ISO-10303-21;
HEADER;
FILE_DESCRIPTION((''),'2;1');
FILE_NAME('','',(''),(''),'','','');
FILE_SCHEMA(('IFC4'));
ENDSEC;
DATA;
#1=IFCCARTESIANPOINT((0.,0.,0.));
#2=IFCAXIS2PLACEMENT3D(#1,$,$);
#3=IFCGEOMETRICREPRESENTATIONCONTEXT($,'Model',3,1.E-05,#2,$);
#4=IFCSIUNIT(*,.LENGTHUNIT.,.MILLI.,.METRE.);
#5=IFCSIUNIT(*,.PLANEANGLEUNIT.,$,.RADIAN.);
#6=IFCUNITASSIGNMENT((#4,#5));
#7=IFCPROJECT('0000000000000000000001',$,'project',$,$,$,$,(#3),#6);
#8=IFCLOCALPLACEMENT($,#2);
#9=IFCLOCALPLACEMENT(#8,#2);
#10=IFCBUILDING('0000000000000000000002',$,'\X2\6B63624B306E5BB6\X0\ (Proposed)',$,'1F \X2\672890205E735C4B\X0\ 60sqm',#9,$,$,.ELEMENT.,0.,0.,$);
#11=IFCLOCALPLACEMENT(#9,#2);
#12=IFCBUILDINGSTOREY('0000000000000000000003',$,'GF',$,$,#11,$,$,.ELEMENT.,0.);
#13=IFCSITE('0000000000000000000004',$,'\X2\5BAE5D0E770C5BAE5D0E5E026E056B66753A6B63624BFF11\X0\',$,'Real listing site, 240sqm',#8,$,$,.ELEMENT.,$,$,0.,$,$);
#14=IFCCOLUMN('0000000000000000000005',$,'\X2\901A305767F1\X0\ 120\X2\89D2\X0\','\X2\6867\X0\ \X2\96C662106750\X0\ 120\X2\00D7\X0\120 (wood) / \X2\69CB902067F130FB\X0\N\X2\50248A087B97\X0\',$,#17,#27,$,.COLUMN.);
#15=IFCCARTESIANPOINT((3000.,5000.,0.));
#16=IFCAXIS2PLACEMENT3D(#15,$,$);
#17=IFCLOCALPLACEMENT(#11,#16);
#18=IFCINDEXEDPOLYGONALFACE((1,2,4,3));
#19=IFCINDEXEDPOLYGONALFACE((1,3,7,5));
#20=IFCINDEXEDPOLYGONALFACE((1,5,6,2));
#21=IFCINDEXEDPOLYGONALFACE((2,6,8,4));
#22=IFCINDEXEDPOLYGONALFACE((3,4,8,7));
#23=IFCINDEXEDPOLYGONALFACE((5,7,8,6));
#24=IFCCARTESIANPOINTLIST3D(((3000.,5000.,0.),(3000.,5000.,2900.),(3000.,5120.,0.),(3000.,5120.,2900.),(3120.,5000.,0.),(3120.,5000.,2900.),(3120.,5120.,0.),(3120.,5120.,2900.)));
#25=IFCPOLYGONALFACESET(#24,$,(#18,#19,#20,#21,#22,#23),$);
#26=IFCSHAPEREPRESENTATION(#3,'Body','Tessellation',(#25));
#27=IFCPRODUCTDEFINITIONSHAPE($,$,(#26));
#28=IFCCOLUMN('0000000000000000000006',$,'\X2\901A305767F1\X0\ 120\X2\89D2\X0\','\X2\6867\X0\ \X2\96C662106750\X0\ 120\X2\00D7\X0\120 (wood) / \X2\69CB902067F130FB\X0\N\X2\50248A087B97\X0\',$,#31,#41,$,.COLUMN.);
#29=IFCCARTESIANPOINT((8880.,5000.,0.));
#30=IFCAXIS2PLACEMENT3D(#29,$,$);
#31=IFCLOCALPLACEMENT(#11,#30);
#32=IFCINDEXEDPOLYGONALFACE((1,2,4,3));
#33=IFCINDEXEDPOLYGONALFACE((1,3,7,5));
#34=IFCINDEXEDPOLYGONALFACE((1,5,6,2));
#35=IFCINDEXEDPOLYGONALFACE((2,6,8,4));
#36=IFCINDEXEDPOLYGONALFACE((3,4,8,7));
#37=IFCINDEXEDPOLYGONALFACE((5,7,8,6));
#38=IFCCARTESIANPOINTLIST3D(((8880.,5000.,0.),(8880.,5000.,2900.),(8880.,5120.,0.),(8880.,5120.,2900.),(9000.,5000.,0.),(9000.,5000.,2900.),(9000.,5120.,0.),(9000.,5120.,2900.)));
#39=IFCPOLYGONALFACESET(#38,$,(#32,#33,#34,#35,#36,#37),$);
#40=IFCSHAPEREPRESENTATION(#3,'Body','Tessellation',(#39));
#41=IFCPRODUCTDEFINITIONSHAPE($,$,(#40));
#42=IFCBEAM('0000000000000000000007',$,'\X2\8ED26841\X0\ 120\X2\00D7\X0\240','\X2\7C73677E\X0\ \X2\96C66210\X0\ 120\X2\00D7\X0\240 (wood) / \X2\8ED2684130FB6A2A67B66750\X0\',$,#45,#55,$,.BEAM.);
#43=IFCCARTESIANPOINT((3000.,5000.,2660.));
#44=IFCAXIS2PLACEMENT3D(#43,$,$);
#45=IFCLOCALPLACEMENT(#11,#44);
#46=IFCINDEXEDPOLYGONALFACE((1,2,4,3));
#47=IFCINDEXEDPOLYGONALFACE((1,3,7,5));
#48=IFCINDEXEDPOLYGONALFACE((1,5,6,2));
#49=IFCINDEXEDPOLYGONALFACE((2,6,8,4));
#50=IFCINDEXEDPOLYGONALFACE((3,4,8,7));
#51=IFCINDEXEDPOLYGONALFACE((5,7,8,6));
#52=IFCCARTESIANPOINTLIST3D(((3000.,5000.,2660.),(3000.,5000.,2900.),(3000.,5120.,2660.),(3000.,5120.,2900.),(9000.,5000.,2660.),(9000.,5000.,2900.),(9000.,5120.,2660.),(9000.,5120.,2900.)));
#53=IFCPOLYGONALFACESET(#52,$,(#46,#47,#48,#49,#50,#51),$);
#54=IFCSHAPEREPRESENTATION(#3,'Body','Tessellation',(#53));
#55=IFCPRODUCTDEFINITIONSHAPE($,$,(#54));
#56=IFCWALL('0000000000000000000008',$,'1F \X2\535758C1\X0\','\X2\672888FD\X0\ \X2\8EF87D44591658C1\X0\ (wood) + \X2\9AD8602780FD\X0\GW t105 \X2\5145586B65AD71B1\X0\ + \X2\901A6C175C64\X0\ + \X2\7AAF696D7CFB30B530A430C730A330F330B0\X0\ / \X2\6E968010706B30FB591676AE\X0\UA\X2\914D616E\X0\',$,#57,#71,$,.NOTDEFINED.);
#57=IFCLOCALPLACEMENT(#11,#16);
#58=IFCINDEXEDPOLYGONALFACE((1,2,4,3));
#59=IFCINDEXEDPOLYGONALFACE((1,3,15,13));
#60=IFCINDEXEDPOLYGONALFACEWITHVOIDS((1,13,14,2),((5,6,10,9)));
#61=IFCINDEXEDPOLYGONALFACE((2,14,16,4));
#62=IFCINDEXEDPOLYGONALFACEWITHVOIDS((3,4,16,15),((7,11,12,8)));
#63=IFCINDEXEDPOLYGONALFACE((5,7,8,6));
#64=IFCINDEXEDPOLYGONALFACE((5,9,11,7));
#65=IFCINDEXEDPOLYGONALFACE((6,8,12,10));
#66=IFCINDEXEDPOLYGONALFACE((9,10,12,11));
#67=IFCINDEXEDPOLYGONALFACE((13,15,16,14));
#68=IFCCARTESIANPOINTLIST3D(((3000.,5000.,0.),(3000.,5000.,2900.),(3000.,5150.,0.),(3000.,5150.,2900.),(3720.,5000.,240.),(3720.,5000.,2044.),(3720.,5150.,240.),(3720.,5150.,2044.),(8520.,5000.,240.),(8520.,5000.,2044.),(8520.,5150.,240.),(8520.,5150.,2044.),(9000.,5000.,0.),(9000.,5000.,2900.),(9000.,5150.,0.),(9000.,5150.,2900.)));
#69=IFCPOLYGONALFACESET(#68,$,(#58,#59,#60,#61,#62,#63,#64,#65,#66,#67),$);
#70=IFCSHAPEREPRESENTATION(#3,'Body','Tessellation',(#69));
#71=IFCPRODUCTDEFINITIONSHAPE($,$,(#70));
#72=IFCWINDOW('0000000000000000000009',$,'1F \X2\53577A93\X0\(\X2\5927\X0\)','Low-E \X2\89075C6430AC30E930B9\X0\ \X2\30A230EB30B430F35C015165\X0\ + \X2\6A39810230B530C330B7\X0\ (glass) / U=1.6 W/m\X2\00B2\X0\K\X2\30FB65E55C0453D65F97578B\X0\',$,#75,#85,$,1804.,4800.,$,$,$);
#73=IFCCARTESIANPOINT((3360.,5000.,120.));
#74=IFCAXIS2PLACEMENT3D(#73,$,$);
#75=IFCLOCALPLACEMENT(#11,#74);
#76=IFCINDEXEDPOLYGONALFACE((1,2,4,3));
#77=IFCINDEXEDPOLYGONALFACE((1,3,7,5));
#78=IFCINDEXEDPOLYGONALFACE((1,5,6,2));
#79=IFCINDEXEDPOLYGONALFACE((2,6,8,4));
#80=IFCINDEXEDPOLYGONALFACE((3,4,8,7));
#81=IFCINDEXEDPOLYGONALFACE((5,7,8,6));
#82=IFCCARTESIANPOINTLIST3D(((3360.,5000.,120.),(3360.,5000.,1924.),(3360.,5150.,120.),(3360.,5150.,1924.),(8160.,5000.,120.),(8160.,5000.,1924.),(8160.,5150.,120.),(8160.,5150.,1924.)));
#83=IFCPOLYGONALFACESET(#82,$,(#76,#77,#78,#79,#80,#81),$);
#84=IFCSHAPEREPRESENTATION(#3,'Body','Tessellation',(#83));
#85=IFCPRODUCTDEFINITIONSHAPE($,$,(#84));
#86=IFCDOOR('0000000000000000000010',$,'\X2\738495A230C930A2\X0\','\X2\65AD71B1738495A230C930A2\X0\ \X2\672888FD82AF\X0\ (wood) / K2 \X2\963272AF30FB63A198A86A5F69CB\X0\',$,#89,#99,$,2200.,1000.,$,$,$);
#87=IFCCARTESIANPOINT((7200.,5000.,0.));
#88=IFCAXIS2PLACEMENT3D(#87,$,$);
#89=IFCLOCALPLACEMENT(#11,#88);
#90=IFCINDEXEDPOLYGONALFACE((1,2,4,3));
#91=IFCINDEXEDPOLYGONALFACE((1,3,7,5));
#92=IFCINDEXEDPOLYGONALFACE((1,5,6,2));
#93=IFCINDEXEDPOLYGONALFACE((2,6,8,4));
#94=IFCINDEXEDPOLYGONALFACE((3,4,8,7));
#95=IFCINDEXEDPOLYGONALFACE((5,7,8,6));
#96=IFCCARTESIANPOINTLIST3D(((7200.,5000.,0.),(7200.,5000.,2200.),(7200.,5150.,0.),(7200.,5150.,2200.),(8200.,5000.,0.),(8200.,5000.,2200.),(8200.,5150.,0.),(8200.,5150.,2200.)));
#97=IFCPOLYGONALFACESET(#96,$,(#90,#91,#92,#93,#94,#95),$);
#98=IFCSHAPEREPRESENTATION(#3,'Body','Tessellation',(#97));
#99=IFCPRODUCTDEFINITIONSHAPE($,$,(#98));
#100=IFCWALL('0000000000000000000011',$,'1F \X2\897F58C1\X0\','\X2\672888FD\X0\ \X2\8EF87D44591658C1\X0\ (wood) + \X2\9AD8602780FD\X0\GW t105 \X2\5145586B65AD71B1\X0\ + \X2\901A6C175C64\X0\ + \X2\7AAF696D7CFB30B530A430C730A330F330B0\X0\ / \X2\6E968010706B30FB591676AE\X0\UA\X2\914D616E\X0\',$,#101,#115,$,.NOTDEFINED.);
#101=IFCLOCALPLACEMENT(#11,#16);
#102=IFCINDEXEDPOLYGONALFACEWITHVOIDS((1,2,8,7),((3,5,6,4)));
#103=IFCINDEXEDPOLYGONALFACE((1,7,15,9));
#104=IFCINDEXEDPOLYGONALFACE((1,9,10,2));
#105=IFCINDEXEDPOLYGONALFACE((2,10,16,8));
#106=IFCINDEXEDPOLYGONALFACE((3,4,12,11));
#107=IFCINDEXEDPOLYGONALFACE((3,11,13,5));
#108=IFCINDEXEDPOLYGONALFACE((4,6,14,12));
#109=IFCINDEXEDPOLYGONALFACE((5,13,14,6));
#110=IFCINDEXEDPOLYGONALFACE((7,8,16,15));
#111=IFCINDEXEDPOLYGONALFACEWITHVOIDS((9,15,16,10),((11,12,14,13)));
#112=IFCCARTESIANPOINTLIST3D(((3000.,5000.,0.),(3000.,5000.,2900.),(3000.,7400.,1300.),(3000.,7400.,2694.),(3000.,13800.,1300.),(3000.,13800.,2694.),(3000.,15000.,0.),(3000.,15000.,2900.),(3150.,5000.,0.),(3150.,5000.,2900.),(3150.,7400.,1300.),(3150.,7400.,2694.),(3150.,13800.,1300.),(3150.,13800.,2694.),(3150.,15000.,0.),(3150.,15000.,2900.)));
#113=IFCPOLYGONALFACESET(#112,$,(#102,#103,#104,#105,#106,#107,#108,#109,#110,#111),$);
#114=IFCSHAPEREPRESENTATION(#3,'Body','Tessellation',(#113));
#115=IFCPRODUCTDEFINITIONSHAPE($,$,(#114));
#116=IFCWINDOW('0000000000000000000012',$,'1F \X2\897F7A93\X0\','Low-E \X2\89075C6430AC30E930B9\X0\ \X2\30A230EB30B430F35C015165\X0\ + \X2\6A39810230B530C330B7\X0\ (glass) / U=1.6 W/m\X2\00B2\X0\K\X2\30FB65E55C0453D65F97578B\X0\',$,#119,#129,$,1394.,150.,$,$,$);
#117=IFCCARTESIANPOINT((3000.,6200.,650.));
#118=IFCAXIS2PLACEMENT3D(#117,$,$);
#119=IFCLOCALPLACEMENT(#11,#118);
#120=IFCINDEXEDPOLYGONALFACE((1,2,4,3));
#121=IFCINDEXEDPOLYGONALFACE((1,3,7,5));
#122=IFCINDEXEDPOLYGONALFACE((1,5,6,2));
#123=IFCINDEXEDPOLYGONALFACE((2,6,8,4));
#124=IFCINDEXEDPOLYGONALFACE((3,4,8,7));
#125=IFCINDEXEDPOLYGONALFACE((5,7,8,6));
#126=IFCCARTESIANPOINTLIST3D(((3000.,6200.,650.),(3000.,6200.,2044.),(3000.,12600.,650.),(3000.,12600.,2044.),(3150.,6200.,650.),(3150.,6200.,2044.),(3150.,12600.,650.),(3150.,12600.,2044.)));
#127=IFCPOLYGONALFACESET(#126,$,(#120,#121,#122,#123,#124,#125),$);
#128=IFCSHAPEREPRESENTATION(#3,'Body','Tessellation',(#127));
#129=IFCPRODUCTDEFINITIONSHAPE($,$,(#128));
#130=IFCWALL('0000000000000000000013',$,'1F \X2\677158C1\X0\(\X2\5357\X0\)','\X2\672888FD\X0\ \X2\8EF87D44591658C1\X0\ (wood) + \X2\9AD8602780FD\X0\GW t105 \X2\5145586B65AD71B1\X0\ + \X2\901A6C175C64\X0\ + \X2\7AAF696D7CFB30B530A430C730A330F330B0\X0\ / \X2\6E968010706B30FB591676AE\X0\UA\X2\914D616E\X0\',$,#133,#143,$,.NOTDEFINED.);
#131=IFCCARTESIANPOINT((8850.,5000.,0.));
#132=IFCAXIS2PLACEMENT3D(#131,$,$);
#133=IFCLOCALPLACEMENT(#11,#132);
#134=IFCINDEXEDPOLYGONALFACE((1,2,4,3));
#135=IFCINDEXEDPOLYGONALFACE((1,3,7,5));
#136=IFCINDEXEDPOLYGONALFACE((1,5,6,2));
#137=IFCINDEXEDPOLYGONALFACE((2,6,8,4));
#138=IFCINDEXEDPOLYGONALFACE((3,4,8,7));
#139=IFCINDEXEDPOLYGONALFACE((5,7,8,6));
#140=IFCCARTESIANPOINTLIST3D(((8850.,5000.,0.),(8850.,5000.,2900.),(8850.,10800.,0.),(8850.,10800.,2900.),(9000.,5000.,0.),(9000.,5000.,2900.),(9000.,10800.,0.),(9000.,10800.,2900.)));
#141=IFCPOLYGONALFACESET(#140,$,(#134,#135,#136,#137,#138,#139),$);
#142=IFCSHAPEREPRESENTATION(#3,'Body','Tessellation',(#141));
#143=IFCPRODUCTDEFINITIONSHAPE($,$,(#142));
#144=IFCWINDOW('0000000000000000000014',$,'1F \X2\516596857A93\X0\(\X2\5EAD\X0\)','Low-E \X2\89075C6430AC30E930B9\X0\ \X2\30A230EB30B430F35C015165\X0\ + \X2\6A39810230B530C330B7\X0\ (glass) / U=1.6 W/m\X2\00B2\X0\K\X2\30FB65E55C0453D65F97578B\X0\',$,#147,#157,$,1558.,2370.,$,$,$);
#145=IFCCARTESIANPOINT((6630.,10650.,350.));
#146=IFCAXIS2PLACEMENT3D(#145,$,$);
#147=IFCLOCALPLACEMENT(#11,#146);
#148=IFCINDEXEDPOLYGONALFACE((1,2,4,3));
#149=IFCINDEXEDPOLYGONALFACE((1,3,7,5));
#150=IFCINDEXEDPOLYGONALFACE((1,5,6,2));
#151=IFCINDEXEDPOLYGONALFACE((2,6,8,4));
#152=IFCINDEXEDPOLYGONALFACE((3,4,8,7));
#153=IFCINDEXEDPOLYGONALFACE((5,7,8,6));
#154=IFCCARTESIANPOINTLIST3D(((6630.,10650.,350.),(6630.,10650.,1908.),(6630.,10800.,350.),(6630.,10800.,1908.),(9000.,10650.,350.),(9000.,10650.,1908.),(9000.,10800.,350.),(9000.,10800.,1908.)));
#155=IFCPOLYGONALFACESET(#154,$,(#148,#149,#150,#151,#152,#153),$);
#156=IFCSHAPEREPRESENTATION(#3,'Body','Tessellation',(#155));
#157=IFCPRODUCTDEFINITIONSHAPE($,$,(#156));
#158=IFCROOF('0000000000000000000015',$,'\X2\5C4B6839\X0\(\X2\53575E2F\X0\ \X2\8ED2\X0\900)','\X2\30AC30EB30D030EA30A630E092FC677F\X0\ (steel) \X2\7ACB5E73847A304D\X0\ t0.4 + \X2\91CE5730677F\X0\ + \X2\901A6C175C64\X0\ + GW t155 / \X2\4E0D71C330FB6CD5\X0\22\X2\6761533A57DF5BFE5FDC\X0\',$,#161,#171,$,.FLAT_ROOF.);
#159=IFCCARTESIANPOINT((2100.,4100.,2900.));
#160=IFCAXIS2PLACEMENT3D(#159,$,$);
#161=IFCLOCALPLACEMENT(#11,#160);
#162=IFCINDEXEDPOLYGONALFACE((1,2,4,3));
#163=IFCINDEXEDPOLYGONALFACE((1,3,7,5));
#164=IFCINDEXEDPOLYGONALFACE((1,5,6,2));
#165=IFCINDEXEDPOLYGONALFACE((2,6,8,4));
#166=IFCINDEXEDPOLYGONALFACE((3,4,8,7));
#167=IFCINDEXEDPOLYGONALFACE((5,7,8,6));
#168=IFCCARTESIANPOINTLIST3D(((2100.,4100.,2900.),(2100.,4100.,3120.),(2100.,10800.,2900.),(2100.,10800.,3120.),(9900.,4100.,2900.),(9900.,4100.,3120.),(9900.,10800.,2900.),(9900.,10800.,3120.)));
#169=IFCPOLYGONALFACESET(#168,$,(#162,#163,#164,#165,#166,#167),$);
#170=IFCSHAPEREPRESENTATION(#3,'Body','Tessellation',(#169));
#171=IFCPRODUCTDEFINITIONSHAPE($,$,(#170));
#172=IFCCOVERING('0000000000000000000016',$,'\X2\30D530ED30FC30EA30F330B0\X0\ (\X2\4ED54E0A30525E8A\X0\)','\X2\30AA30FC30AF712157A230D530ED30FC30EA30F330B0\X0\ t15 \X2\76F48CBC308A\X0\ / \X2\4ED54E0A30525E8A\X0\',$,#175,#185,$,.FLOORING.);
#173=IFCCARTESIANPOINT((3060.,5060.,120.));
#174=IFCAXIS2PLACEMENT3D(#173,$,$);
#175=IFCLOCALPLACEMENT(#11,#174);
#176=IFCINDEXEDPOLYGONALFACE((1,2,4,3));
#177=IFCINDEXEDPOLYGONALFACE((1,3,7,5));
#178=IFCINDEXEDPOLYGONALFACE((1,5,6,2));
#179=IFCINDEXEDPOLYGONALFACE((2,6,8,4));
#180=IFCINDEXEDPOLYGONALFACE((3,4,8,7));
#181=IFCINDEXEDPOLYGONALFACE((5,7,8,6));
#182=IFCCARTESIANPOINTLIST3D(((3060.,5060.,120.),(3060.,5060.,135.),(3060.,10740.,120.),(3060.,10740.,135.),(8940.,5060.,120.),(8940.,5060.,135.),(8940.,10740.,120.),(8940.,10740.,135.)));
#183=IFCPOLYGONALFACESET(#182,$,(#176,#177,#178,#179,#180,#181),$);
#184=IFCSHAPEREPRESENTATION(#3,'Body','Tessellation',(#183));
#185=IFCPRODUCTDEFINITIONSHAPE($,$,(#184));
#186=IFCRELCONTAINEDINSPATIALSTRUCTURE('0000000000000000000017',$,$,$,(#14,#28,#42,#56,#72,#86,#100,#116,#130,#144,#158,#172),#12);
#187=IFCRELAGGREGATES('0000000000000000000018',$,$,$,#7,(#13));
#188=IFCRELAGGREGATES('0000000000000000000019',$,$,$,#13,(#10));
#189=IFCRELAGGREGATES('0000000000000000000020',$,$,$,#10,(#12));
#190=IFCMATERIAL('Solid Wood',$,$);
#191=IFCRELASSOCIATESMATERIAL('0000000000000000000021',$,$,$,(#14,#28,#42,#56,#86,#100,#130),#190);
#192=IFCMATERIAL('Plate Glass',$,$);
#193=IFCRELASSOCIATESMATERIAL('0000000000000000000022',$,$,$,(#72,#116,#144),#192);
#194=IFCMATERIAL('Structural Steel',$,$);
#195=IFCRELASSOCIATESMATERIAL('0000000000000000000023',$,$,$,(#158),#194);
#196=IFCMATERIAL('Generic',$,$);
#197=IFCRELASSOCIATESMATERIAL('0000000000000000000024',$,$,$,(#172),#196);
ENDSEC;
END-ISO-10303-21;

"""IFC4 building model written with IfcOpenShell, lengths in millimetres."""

from ifc_helpers import new_model, si_unit, frame, frame_2d, origin, place, context, project, spatial, rectangle, extrude, material, element, fill, save


model = new_model("IFC4")

# Units and contexts
model_context = context("Model", 3, precision=1e-05, world=origin())
ifc_project = project(units=[si_unit("LENGTHUNIT", "METRE", prefix="MILLI"), si_unit("PLANEANGLEUNIT", "RADIAN")], contexts=[model_context])

# Site, building, storey
site_placement = place(None, origin())
site = spatial("IfcSite", under=ifc_project, at=site_placement, Name="宮崎県宮崎市清武町正手１", ObjectType="Real listing site, 240sqm", CompositionType="ELEMENT", RefElevation=0.0)
building_placement = place(site_placement, origin())
building = spatial("IfcBuilding", under=site, at=building_placement, Name="正手の家 (Proposed)", ObjectType="1F 木造平屋 60sqm", CompositionType="ELEMENT", ElevationOfRefHeight=0.0, ElevationOfTerrain=0.0)
storey_placement = place(building_placement, origin())
storey = spatial("IfcBuildingStorey", under=building, at=storey_placement, Name="GF", CompositionType="ELEMENT", Elevation=0.0)

# Columns
ifc_material_1 = material(Name="Solid Wood")
column_1_placement = place(storey_placement, frame((3000.0, 5000.0, 0.0)))
element("IfcColumn", 1, at=column_1_placement, inside=storey, material=ifc_material_1, Name="通し柱 120角", Description="桧 集成材 120×120 (wood) / 構造柱・N値計算", PredefinedType="COLUMN", context=model_context, shape_type="SweptSolid", body=[
    extrude(rectangle(XDim=120.0, YDim=120.0, at=frame_2d((60.0, 60.0))), frame((3000.0, 5000.0, 0.0)), (0.0, 0.0, 1.0), 2900.0),
])
column_2_placement = place(storey_placement, frame((8880.0, 5000.0, 0.0)))
element("IfcColumn", 2, at=column_2_placement, inside=storey, material=ifc_material_1, Name="通し柱 120角", Description="桧 集成材 120×120 (wood) / 構造柱・N値計算", PredefinedType="COLUMN", context=model_context, shape_type="SweptSolid", body=[
    extrude(rectangle(XDim=120.0, YDim=120.0, at=frame_2d((60.0, 60.0))), frame((8880.0, 5000.0, 0.0)), (0.0, 0.0, 1.0), 2900.0),
])

# Beam
beam_1_placement = place(storey_placement, frame((3000.0, 5000.0, 2660.0)))
element("IfcBeam", 3, at=beam_1_placement, inside=storey, material=ifc_material_1, Name="軒桁 120×240", Description="米松 集成 120×240 (wood) / 軒桁・横架材", PredefinedType="BEAM", context=model_context, shape_type="SweptSolid", body=[
    extrude(rectangle(XDim=6000.0, YDim=120.0, at=frame_2d((3000.0, 60.0))), frame((3000.0, 5000.0, 2660.0)), (0.0, 0.0, 1.0), 240.0),
])

# Wall, openings, window, door
wall_1_placement = place(storey_placement, frame((3000.0, 5000.0, 0.0)))
wall_1 = element("IfcWall", 4, at=wall_1_placement, inside=storey, material=ifc_material_1, Name="1F 南壁", Description="木製 軸組外壁 (wood) + 高性能GW t105 充填断熱 + 通気層 + 窯業系サイディング / 準耐火・外皮UA配慮", PredefinedType="NOTDEFINED", context=model_context, shape_type="SweptSolid", body=[
    extrude(rectangle(XDim=6000.0, YDim=150.0, at=frame_2d((3000.0, 75.0))), frame((3000.0, 5000.0, 0.0)), (0.0, 0.0, 1.0), 2900.0),
])
opening_1_placement = place(storey_placement, frame((3360.0, 5000.0, 120.0)))
opening_1 = element("IfcOpeningElement", 5, at=opening_1_placement, cuts=wall_1, PredefinedType="NOTDEFINED", context=model_context, shape_type="SweptSolid", body=[
    extrude(rectangle(XDim=4800.0, YDim=150.0, at=frame_2d((2400.0, 75.0))), frame((3360.0, 5000.0, 120.0)), (0.0, 0.0, 1.0), 1804.0),
])
opening_2_placement = place(storey_placement, frame((7200.0, 5000.0, 0.0)))
opening_2 = element("IfcOpeningElement", 6, at=opening_2_placement, cuts=wall_1, PredefinedType="NOTDEFINED", context=model_context, shape_type="SweptSolid", body=[
    extrude(rectangle(XDim=1000.0, YDim=150.0, at=frame_2d((500.0, 75.0))), frame((7200.0, 5000.0, 0.0)), (0.0, 0.0, 1.0), 2200.0),
])
ifc_material_2 = material(Name="Plate Glass")
window_1_placement = place(storey_placement, frame((3360.0, 5000.0, 120.0)))
window_1 = element("IfcWindow", 7, at=window_1_placement, inside=storey, material=ifc_material_2, Name="1F 南窓(大)", Description="Low-E 複層ガラス アルゴン封入 + 樹脂サッシ (glass) / U=1.6 W/m²K・日射取得型", OverallHeight=1804.0, OverallWidth=4800.0, context=model_context, shape_type="SweptSolid", body=[
    extrude(rectangle(XDim=4800.0, YDim=150.0, at=frame_2d((2400.0, 75.0))), frame((3360.0, 5000.0, 120.0)), (0.0, 0.0, 1.0), 1804.0),
])
fill(opening_1, window_1)
door_1_placement = place(storey_placement, frame((7200.0, 5000.0, 0.0)))
door_1 = element("IfcDoor", 8, at=door_1_placement, inside=storey, material=ifc_material_1, Name="玄関ドア", Description="断熱玄関ドア 木製芯 (wood) / K2 防犯・採風機構", OverallHeight=2200.0, OverallWidth=1000.0, context=model_context, shape_type="SweptSolid", body=[
    extrude(rectangle(XDim=1000.0, YDim=150.0, at=frame_2d((500.0, 75.0))), frame((7200.0, 5000.0, 0.0)), (0.0, 0.0, 1.0), 2200.0),
])
fill(opening_2, door_1)

# Walls, openings, windows
wall_2_placement = place(storey_placement, frame((3000.0, 5000.0, 0.0)))
wall_2 = element("IfcWall", 9, at=wall_2_placement, inside=storey, material=ifc_material_1, Name="1F 西壁", Description="木製 軸組外壁 (wood) + 高性能GW t105 充填断熱 + 通気層 + 窯業系サイディング / 準耐火・外皮UA配慮", PredefinedType="NOTDEFINED", context=model_context, shape_type="SweptSolid", body=[
    extrude(rectangle(XDim=150.0, YDim=10000.0, at=frame_2d((75.0, 5000.0))), frame((3000.0, 5000.0, 0.0)), (0.0, 0.0, 1.0), 2900.0),
])
opening_3_placement = place(storey_placement, frame((3000.0, 6200.0, 650.0)))
opening_3 = element("IfcOpeningElement", 10, at=opening_3_placement, cuts=wall_2, PredefinedType="NOTDEFINED", context=model_context, shape_type="SweptSolid", body=[
    extrude(rectangle(XDim=150.0, YDim=6400.0, at=frame_2d((75.0, 3200.0))), frame((3000.0, 6200.0, 650.0)), (0.0, 0.0, 1.0), 1394.0),
])
window_2_placement = place(storey_placement, frame((3000.0, 6200.0, 650.0)))
window_2 = element("IfcWindow", 11, at=window_2_placement, inside=storey, material=ifc_material_2, Name="1F 西窓", Description="Low-E 複層ガラス アルゴン封入 + 樹脂サッシ (glass) / U=1.6 W/m²K・日射取得型", OverallHeight=1394.0, OverallWidth=150.0, context=model_context, shape_type="SweptSolid", body=[
    extrude(rectangle(XDim=150.0, YDim=6400.0, at=frame_2d((75.0, 3200.0))), frame((3000.0, 6200.0, 650.0)), (0.0, 0.0, 1.0), 1394.0),
])
fill(opening_3, window_2)
wall_3_placement = place(storey_placement, frame((8850.0, 5000.0, 0.0)))
wall_3 = element("IfcWall", 12, at=wall_3_placement, inside=storey, material=ifc_material_1, Name="1F 東壁(南)", Description="木製 軸組外壁 (wood) + 高性能GW t105 充填断熱 + 通気層 + 窯業系サイディング / 準耐火・外皮UA配慮", PredefinedType="NOTDEFINED", context=model_context, shape_type="SweptSolid", body=[
    extrude(rectangle(XDim=150.0, YDim=5800.0, at=frame_2d((75.0, 2900.0))), frame((8850.0, 5000.0, 0.0)), (0.0, 0.0, 1.0), 2900.0),
])
opening_4_placement = place(storey_placement, frame((6630.0, 10650.0, 350.0)))
opening_4 = element("IfcOpeningElement", 13, at=opening_4_placement, cuts=wall_3, PredefinedType="NOTDEFINED", context=model_context, shape_type="SweptSolid", body=[
    extrude(rectangle(XDim=2370.0, YDim=150.0, at=frame_2d((1185.0, 75.0))), frame((6630.0, 10650.0, 350.0)), (0.0, 0.0, 1.0), 1558.0),
])
window_3_placement = place(storey_placement, frame((6630.0, 10650.0, 350.0)))
window_3 = element("IfcWindow", 14, at=window_3_placement, inside=storey, material=ifc_material_2, Name="1F 入隅窓(庭)", Description="Low-E 複層ガラス アルゴン封入 + 樹脂サッシ (glass) / U=1.6 W/m²K・日射取得型", OverallHeight=1558.0, OverallWidth=2370.0, context=model_context, shape_type="SweptSolid", body=[
    extrude(rectangle(XDim=2370.0, YDim=150.0, at=frame_2d((1185.0, 75.0))), frame((6630.0, 10650.0, 350.0)), (0.0, 0.0, 1.0), 1558.0),
])
fill(opening_4, window_3)

# Roof
ifc_material_3 = material(Name="Structural Steel")
roof_placement = place(storey_placement, frame((2100.0, 4100.0, 2900.0)))
element("IfcRoof", 15, at=roof_placement, inside=storey, material=ifc_material_3, Name="屋根(南帯 軒900)", Description="ガルバリウム鋼板 (steel) 立平葺き t0.4 + 野地板 + 通気層 + GW t155 / 不燃・法22条区域対応", PredefinedType="FLAT_ROOF", context=model_context, shape_type="SweptSolid", body=[
    extrude(rectangle(XDim=7800.0, YDim=6700.0, at=frame_2d((3900.0, 3350.0))), frame((2100.0, 4100.0, 2900.0)), (0.0, 0.0, 1.0), 220.0),
])

# Covering
ifc_material_4 = material(Name="Generic")
covering_1_placement = place(storey_placement, frame((3060.0, 5060.0, 120.0)))
element("IfcCovering", 16, at=covering_1_placement, inside=storey, material=ifc_material_4, Name="フローリング (仕上げ床)", Description="オーク無垢フローリング t15 直貼り / 仕上げ床", PredefinedType="FLOORING", context=model_context, shape_type="SweptSolid", body=[
    extrude(rectangle(XDim=5880.0, YDim=5680.0, at=frame_2d((2940.0, 2840.0))), frame((3060.0, 5060.0, 120.0)), (0.0, 0.0, 1.0), 15.0),
])

save(model, "model.ifc")
